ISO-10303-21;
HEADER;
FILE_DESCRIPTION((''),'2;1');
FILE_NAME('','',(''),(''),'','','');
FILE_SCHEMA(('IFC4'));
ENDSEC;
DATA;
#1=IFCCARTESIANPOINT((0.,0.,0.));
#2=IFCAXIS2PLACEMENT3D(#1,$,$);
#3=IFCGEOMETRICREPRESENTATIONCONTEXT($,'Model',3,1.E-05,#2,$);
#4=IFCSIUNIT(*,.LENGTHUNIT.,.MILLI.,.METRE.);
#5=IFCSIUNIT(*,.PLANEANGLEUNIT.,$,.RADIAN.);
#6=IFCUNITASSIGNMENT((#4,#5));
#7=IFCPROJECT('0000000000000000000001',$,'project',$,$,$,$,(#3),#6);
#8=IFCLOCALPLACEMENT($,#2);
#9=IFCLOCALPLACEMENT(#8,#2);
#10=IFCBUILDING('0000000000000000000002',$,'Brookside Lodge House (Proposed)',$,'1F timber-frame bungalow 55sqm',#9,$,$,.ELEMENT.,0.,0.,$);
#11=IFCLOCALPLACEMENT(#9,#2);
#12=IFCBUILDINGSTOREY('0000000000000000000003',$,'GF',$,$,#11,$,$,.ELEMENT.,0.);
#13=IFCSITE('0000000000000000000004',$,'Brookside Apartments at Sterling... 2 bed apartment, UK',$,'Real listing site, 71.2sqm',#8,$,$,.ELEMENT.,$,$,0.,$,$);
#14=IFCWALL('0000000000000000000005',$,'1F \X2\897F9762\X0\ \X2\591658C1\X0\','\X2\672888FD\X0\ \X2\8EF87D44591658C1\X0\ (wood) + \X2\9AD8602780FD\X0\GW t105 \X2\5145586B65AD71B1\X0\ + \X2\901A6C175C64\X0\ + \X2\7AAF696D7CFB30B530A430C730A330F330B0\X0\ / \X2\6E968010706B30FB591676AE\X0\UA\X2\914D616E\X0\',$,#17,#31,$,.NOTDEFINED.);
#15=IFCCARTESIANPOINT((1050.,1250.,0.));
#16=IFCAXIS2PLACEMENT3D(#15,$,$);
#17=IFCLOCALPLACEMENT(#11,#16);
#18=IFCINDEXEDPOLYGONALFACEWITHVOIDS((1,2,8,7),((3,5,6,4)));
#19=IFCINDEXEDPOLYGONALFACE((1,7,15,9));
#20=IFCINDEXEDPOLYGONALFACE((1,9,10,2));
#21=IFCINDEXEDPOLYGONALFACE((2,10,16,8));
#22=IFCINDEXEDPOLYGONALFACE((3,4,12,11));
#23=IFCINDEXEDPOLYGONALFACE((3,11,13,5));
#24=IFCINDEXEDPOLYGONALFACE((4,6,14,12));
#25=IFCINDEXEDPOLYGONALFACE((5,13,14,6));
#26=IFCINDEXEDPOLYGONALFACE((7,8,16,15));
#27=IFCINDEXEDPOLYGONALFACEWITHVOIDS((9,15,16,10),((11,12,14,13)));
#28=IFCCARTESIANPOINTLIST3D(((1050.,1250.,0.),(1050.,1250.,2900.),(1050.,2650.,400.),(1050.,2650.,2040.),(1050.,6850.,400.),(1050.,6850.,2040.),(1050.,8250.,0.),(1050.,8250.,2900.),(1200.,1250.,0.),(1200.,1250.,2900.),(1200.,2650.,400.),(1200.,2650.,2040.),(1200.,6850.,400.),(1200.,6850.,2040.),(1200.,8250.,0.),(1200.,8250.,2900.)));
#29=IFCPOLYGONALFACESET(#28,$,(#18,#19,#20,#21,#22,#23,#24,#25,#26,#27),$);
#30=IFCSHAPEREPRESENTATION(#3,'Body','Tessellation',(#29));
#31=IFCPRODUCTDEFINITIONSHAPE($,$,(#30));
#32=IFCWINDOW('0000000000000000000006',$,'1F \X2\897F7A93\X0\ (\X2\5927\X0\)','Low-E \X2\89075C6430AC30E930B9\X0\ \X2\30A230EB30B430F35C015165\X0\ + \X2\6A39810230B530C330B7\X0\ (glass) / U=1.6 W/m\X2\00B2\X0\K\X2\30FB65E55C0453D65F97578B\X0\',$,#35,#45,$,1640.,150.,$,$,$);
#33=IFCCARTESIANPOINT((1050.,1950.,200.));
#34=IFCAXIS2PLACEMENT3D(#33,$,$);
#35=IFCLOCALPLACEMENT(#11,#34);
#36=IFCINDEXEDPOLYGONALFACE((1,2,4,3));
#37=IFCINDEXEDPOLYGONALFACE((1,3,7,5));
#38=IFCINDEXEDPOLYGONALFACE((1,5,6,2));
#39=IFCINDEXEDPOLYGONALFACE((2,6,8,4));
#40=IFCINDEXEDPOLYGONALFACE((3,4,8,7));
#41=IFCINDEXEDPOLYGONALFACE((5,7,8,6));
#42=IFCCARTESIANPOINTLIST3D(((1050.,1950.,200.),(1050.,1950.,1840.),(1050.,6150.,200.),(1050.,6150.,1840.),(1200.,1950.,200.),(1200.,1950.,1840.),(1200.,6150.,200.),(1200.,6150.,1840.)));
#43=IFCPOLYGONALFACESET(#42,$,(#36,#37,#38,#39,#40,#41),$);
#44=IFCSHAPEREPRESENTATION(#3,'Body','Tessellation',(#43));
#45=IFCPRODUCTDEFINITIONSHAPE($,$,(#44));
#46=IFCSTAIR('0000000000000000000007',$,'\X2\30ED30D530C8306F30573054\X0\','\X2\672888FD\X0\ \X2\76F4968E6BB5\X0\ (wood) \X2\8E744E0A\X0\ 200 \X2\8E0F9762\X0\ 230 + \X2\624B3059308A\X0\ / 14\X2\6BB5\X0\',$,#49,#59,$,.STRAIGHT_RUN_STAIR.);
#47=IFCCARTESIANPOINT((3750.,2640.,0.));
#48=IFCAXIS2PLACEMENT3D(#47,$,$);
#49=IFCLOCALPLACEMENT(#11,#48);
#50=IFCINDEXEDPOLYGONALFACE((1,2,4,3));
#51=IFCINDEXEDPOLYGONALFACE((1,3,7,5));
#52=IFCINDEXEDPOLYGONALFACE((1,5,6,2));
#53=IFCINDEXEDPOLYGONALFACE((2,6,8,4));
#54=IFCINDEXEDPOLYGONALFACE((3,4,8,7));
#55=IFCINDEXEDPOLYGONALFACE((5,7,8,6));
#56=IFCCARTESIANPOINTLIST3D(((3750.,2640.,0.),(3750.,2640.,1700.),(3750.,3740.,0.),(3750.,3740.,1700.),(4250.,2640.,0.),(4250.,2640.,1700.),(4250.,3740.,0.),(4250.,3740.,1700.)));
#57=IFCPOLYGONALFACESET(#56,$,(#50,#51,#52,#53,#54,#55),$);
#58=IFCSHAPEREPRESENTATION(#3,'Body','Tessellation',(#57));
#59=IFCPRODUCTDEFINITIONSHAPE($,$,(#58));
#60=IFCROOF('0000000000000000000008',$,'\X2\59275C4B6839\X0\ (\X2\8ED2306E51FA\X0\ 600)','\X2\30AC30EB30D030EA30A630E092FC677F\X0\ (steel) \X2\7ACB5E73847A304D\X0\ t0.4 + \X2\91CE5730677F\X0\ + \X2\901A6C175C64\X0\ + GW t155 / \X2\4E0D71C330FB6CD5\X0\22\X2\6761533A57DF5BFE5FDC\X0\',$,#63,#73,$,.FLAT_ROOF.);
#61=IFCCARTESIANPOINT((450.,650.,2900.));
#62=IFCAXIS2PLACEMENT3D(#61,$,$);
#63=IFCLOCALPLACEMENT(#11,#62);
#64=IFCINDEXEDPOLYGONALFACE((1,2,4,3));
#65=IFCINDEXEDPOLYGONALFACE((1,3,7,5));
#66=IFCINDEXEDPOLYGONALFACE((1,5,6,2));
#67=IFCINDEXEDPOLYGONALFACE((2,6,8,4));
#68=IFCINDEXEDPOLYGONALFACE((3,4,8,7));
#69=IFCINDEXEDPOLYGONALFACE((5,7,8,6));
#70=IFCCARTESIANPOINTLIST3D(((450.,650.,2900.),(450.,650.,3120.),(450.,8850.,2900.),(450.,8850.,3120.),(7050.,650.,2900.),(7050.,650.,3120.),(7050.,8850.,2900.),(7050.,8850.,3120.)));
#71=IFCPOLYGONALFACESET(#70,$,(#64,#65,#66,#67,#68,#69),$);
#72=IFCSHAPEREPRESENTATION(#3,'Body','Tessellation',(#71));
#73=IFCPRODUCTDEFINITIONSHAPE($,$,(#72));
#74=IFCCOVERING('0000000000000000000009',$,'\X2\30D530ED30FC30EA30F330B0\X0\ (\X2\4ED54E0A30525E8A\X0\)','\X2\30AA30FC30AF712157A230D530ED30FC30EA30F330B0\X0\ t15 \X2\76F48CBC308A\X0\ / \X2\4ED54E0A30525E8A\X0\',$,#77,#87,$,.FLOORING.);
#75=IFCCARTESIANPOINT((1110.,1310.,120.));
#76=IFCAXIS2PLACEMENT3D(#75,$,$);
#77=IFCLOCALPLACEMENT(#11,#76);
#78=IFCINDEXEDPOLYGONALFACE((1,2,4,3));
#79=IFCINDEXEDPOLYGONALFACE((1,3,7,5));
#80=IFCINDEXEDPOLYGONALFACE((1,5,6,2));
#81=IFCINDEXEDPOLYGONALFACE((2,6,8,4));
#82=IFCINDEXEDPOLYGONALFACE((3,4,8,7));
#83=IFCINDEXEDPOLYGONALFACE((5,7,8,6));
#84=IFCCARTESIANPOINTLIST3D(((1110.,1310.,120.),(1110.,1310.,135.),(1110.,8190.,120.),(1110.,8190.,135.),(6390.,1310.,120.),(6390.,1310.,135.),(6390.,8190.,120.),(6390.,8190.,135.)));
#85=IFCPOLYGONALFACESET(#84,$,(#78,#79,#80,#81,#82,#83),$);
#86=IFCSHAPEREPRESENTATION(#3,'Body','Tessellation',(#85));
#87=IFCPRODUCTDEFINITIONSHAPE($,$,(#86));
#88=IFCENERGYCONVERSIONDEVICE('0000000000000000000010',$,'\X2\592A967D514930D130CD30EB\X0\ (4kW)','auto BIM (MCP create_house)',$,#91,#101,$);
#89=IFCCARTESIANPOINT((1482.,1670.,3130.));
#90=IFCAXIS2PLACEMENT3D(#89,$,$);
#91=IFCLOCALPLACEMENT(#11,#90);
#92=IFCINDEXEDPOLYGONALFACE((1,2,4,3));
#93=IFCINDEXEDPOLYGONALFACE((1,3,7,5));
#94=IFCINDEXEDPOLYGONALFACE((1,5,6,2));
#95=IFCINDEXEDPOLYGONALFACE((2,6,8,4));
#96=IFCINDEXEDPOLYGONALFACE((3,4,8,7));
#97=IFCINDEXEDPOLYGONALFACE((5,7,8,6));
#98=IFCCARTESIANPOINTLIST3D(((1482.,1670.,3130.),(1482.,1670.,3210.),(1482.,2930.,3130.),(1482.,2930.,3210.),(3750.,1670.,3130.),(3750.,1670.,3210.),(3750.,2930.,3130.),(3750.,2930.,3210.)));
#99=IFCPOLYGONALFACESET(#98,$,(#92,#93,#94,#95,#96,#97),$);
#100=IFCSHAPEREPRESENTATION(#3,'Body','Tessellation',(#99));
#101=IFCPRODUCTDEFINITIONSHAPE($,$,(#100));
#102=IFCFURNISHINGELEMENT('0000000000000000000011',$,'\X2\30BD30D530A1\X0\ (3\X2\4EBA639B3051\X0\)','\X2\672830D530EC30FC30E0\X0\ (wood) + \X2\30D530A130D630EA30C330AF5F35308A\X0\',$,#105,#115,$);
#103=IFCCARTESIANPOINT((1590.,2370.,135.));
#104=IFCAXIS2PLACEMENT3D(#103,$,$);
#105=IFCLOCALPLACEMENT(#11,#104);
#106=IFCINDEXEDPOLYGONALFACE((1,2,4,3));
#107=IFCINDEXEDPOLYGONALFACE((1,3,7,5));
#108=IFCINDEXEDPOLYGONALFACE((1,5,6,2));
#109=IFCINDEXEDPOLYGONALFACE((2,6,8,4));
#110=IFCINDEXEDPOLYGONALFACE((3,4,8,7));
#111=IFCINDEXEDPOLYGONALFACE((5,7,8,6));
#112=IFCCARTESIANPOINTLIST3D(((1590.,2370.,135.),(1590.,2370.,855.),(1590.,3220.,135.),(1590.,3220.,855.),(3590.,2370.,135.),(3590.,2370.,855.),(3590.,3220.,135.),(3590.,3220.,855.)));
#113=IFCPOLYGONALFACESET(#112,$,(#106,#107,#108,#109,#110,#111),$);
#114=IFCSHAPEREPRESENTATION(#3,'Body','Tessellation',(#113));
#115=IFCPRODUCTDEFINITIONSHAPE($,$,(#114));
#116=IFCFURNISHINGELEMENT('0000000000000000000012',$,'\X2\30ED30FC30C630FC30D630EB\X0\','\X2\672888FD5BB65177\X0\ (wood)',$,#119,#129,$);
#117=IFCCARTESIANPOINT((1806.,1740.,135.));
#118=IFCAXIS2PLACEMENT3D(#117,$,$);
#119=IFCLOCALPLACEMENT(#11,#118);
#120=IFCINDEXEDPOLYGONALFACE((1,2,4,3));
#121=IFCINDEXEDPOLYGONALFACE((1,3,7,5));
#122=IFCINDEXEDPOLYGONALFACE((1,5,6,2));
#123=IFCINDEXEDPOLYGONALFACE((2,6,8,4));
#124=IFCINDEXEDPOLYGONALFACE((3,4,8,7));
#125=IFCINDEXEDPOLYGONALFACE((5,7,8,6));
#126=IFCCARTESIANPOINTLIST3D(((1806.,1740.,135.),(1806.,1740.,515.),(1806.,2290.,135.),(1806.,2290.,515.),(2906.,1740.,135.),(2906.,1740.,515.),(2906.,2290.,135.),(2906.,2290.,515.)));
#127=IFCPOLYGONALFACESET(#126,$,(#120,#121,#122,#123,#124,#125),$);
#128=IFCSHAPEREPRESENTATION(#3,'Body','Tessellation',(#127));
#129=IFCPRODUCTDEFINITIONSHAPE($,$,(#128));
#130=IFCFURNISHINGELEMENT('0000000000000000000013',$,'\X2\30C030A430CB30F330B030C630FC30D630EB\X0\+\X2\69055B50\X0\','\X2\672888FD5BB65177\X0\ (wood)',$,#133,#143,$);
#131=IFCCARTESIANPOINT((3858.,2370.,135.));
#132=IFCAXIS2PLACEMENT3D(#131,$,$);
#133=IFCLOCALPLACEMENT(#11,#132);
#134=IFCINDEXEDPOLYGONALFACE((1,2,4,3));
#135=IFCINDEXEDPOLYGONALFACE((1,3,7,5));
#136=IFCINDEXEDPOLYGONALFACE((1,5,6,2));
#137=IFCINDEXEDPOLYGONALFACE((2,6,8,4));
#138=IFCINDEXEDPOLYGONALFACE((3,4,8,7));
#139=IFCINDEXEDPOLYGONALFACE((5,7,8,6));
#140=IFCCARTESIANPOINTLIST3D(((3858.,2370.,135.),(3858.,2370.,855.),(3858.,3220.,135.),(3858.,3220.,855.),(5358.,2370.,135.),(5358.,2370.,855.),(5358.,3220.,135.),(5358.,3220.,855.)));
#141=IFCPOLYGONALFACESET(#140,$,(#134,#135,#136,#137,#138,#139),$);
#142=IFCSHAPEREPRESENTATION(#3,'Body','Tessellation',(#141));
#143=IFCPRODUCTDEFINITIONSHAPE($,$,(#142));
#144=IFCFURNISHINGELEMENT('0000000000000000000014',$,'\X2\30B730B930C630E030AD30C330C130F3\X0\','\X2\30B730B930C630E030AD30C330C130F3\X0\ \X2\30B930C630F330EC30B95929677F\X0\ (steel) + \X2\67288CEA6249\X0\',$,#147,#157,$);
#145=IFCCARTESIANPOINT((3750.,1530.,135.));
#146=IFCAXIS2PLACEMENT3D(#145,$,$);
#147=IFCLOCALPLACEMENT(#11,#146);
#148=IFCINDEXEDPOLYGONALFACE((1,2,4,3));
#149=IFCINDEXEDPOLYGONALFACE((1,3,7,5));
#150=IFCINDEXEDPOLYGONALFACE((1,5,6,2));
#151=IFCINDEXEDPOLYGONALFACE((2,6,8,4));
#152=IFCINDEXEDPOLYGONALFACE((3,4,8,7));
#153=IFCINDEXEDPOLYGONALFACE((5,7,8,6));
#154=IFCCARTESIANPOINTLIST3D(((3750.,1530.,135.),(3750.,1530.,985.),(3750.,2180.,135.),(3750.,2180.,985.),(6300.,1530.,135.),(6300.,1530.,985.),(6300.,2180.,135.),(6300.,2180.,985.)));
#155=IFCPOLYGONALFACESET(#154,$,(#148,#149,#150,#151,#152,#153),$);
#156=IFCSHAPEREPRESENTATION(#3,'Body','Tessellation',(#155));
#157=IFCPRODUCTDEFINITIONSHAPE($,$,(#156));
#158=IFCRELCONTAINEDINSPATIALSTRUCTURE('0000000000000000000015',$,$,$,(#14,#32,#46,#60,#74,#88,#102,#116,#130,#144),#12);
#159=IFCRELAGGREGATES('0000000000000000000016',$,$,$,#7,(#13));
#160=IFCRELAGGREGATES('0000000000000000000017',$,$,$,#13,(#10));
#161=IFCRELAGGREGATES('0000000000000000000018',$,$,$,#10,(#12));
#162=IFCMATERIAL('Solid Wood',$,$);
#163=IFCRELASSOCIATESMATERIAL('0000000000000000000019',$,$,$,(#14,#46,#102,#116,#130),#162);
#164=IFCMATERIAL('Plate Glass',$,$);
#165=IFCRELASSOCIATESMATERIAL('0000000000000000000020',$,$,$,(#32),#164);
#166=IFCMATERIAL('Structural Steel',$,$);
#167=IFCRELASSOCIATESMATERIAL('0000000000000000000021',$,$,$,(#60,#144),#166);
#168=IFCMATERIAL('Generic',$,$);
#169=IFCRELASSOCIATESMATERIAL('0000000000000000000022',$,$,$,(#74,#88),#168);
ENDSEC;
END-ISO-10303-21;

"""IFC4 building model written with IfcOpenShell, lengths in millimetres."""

from ifc_helpers import new_model, si_unit, frame, frame_2d, origin, place, context, project, spatial, rectangle, extrude, material, element, fill, save


model = new_model("IFC4")

# Units and contexts
model_context = context("Model", 3, precision=1e-05, world=origin())
ifc_project = project(units=[si_unit("LENGTHUNIT", "METRE", prefix="MILLI"), si_unit("PLANEANGLEUNIT", "RADIAN")], contexts=[model_context])

# Site, building, storey
site_placement = place(None, origin())
site = spatial("IfcSite", under=ifc_project, at=site_placement, Name="Brookside Apartments at Sterling... 2 bed apartment, UK", ObjectType="Real listing site, 71.2sqm", CompositionType="ELEMENT", RefElevation=0.0)
building_placement = place(site_placement, origin())
building = spatial("IfcBuilding", under=site, at=building_placement, Name="Brookside Lodge House (Proposed)", ObjectType="1F timber-frame bungalow 55sqm", CompositionType="ELEMENT", ElevationOfRefHeight=0.0, ElevationOfTerrain=0.0)
storey_placement = place(building_placement, origin())
storey = spatial("IfcBuildingStorey", under=building, at=storey_placement, Name="GF", CompositionType="ELEMENT", Elevation=0.0)

# Shared definitions
ifc_material_1 = material(Name="Solid Wood")
ifc_material_2 = material(Name="Generic")

# Shared definitions
ifc_material_3 = material(Name="Plate Glass")

# Wall, opening, window
wall_1_placement = place(storey_placement, frame((1050.0, 1250.0, 0.0)))
wall_1 = element("IfcWall", 1, at=wall_1_placement, inside=storey, material=ifc_material_1, Name="1F 西面 外壁", Description="木製 軸組外壁 (wood) + 高性能GW t105 充填断熱 + 通気層 + 窯業系サイディング / 準耐火・外皮UA配慮", PredefinedType="NOTDEFINED", context=model_context, shape_type="SweptSolid", body=[
    extrude(rectangle(XDim=150.0, YDim=7000.0, at=frame_2d((75.0, 3500.0))), frame((1050.0, 1250.0, 0.0)), (0.0, 0.0, 1.0), 2900.0),
])
opening_1_placement = place(storey_placement, frame((1050.0, 1950.0, 200.0)))
opening_1 = element("IfcOpeningElement", 2, at=opening_1_placement, cuts=wall_1, PredefinedType="NOTDEFINED", context=model_context, shape_type="SweptSolid", body=[
    extrude(rectangle(XDim=150.0, YDim=4200.0, at=frame_2d((75.0, 2100.0))), frame((1050.0, 1950.0, 200.0)), (0.0, 0.0, 1.0), 1640.0),
])
window_1_placement = place(storey_placement, frame((1050.0, 1950.0, 200.0)))
window_1 = element("IfcWindow", 3, at=window_1_placement, inside=storey, material=ifc_material_3, Name="1F 西窓 (大)", Description="Low-E 複層ガラス アルゴン封入 + 樹脂サッシ (glass) / U=1.6 W/m²K・日射取得型", OverallHeight=1640.0, OverallWidth=150.0, context=model_context, shape_type="SweptSolid", body=[
    extrude(rectangle(XDim=150.0, YDim=4200.0, at=frame_2d((75.0, 2100.0))), frame((1050.0, 1950.0, 200.0)), (0.0, 0.0, 1.0), 1640.0),
])
fill(opening_1, window_1)

# Stair
stair_placement = place(storey_placement, frame((3750.0, 2640.0, 0.0)))
element("IfcStair", 4, at=stair_placement, inside=storey, material=ifc_material_1, Name="ロフトはしご", Description="木製 直階段 (wood) 蹴上 200 踏面 230 + 手すり / 14段", PredefinedType="STRAIGHT_RUN_STAIR", context=model_context, shape_type="SweptSolid", body=[
    extrude(rectangle(XDim=500.0, YDim=1100.0, at=frame_2d((250.0, 550.0))), frame((3750.0, 2640.0, 0.0)), (0.0, 0.0, 1.0), 1700.0),
])

# Roof
ifc_material_4 = material(Name="Structural Steel")
roof_placement = place(storey_placement, frame((450.0, 650.0, 2900.0)))
element("IfcRoof", 5, at=roof_placement, inside=storey, material=ifc_material_4, Name="大屋根 (軒の出 600)", Description="ガルバリウム鋼板 (steel) 立平葺き t0.4 + 野地板 + 通気層 + GW t155 / 不燃・法22条区域対応", PredefinedType="FLAT_ROOF", context=model_context, shape_type="SweptSolid", body=[
    extrude(rectangle(XDim=6600.0, YDim=8200.0, at=frame_2d((3300.0, 4100.0))), frame((450.0, 650.0, 2900.0)), (0.0, 0.0, 1.0), 220.0),
])

# Covering
covering_placement = place(storey_placement, frame((1110.0, 1310.0, 120.0)))
element("IfcCovering", 6, at=covering_placement, inside=storey, material=ifc_material_2, Name="フローリング (仕上げ床)", Description="オーク無垢フローリング t15 直貼り / 仕上げ床", PredefinedType="FLOORING", context=model_context, shape_type="SweptSolid", body=[
    extrude(rectangle(XDim=5280.0, YDim=6880.0, at=frame_2d((2640.0, 3440.0))), frame((1110.0, 1310.0, 120.0)), (0.0, 0.0, 1.0), 15.0),
])

# Energy conversion device
energy_conversion_device_placement = place(storey_placement, frame((1482.0, 1670.0, 3130.0)))
element("IfcEnergyConversionDevice", 7, at=energy_conversion_device_placement, inside=storey, material=ifc_material_2, Name="太陽光パネル (4kW)", Description="auto BIM (MCP create_house)", context=model_context, shape_type="SweptSolid", body=[
    extrude(rectangle(XDim=2268.0, YDim=1260.0, at=frame_2d((1134.0, 630.0))), frame((1482.0, 1670.0, 3130.0)), (0.0, 0.0, 1.0), 80.0),
])

# Furnishing elements
furnishing_1_placement = place(storey_placement, frame((1590.0, 2370.0, 135.0)))
element("IfcFurnishingElement", 8, at=furnishing_1_placement, inside=storey, material=ifc_material_1, Name="ソファ (3人掛け)", Description="木フレーム (wood) + ファブリック張り", context=model_context, shape_type="SweptSolid", body=[
    extrude(rectangle(XDim=2000.0, YDim=850.0, at=frame_2d((1000.0, 425.0))), frame((1590.0, 2370.0, 135.0)), (0.0, 0.0, 1.0), 720.0),
])
furnishing_2_placement = place(storey_placement, frame((1806.0, 1740.0, 135.0)))
element("IfcFurnishingElement", 9, at=furnishing_2_placement, inside=storey, material=ifc_material_1, Name="ローテーブル", Description="木製家具 (wood)", context=model_context, shape_type="SweptSolid", body=[
    extrude(rectangle(XDim=1100.0, YDim=550.0, at=frame_2d((550.0, 275.0))), frame((1806.0, 1740.0, 135.0)), (0.0, 0.0, 1.0), 380.0),
])
furnishing_3_placement = place(storey_placement, frame((3858.0, 2370.0, 135.0)))
element("IfcFurnishingElement", 10, at=furnishing_3_placement, inside=storey, material=ifc_material_1, Name="ダイニングテーブル+椅子", Description="木製家具 (wood)", context=model_context, shape_type="SweptSolid", body=[
    extrude(rectangle(XDim=1500.0, YDim=850.0, at=frame_2d((750.0, 425.0))), frame((3858.0, 2370.0, 135.0)), (0.0, 0.0, 1.0), 720.0),
])
furnishing_4_placement = place(storey_placement, frame((3750.0, 1530.0, 135.0)))
element("IfcFurnishingElement", 11, at=furnishing_4_placement, inside=storey, material=ifc_material_4, Name="システムキッチン", Description="システムキッチン ステンレス天板 (steel) + 木質扉", context=model_context, shape_type="SweptSolid", body=[
    extrude(rectangle(XDim=2550.0, YDim=650.0, at=frame_2d((1275.0, 325.0))), frame((3750.0, 1530.0, 135.0)), (0.0, 0.0, 1.0), 850.0),
])

save(model, "model.ifc")
